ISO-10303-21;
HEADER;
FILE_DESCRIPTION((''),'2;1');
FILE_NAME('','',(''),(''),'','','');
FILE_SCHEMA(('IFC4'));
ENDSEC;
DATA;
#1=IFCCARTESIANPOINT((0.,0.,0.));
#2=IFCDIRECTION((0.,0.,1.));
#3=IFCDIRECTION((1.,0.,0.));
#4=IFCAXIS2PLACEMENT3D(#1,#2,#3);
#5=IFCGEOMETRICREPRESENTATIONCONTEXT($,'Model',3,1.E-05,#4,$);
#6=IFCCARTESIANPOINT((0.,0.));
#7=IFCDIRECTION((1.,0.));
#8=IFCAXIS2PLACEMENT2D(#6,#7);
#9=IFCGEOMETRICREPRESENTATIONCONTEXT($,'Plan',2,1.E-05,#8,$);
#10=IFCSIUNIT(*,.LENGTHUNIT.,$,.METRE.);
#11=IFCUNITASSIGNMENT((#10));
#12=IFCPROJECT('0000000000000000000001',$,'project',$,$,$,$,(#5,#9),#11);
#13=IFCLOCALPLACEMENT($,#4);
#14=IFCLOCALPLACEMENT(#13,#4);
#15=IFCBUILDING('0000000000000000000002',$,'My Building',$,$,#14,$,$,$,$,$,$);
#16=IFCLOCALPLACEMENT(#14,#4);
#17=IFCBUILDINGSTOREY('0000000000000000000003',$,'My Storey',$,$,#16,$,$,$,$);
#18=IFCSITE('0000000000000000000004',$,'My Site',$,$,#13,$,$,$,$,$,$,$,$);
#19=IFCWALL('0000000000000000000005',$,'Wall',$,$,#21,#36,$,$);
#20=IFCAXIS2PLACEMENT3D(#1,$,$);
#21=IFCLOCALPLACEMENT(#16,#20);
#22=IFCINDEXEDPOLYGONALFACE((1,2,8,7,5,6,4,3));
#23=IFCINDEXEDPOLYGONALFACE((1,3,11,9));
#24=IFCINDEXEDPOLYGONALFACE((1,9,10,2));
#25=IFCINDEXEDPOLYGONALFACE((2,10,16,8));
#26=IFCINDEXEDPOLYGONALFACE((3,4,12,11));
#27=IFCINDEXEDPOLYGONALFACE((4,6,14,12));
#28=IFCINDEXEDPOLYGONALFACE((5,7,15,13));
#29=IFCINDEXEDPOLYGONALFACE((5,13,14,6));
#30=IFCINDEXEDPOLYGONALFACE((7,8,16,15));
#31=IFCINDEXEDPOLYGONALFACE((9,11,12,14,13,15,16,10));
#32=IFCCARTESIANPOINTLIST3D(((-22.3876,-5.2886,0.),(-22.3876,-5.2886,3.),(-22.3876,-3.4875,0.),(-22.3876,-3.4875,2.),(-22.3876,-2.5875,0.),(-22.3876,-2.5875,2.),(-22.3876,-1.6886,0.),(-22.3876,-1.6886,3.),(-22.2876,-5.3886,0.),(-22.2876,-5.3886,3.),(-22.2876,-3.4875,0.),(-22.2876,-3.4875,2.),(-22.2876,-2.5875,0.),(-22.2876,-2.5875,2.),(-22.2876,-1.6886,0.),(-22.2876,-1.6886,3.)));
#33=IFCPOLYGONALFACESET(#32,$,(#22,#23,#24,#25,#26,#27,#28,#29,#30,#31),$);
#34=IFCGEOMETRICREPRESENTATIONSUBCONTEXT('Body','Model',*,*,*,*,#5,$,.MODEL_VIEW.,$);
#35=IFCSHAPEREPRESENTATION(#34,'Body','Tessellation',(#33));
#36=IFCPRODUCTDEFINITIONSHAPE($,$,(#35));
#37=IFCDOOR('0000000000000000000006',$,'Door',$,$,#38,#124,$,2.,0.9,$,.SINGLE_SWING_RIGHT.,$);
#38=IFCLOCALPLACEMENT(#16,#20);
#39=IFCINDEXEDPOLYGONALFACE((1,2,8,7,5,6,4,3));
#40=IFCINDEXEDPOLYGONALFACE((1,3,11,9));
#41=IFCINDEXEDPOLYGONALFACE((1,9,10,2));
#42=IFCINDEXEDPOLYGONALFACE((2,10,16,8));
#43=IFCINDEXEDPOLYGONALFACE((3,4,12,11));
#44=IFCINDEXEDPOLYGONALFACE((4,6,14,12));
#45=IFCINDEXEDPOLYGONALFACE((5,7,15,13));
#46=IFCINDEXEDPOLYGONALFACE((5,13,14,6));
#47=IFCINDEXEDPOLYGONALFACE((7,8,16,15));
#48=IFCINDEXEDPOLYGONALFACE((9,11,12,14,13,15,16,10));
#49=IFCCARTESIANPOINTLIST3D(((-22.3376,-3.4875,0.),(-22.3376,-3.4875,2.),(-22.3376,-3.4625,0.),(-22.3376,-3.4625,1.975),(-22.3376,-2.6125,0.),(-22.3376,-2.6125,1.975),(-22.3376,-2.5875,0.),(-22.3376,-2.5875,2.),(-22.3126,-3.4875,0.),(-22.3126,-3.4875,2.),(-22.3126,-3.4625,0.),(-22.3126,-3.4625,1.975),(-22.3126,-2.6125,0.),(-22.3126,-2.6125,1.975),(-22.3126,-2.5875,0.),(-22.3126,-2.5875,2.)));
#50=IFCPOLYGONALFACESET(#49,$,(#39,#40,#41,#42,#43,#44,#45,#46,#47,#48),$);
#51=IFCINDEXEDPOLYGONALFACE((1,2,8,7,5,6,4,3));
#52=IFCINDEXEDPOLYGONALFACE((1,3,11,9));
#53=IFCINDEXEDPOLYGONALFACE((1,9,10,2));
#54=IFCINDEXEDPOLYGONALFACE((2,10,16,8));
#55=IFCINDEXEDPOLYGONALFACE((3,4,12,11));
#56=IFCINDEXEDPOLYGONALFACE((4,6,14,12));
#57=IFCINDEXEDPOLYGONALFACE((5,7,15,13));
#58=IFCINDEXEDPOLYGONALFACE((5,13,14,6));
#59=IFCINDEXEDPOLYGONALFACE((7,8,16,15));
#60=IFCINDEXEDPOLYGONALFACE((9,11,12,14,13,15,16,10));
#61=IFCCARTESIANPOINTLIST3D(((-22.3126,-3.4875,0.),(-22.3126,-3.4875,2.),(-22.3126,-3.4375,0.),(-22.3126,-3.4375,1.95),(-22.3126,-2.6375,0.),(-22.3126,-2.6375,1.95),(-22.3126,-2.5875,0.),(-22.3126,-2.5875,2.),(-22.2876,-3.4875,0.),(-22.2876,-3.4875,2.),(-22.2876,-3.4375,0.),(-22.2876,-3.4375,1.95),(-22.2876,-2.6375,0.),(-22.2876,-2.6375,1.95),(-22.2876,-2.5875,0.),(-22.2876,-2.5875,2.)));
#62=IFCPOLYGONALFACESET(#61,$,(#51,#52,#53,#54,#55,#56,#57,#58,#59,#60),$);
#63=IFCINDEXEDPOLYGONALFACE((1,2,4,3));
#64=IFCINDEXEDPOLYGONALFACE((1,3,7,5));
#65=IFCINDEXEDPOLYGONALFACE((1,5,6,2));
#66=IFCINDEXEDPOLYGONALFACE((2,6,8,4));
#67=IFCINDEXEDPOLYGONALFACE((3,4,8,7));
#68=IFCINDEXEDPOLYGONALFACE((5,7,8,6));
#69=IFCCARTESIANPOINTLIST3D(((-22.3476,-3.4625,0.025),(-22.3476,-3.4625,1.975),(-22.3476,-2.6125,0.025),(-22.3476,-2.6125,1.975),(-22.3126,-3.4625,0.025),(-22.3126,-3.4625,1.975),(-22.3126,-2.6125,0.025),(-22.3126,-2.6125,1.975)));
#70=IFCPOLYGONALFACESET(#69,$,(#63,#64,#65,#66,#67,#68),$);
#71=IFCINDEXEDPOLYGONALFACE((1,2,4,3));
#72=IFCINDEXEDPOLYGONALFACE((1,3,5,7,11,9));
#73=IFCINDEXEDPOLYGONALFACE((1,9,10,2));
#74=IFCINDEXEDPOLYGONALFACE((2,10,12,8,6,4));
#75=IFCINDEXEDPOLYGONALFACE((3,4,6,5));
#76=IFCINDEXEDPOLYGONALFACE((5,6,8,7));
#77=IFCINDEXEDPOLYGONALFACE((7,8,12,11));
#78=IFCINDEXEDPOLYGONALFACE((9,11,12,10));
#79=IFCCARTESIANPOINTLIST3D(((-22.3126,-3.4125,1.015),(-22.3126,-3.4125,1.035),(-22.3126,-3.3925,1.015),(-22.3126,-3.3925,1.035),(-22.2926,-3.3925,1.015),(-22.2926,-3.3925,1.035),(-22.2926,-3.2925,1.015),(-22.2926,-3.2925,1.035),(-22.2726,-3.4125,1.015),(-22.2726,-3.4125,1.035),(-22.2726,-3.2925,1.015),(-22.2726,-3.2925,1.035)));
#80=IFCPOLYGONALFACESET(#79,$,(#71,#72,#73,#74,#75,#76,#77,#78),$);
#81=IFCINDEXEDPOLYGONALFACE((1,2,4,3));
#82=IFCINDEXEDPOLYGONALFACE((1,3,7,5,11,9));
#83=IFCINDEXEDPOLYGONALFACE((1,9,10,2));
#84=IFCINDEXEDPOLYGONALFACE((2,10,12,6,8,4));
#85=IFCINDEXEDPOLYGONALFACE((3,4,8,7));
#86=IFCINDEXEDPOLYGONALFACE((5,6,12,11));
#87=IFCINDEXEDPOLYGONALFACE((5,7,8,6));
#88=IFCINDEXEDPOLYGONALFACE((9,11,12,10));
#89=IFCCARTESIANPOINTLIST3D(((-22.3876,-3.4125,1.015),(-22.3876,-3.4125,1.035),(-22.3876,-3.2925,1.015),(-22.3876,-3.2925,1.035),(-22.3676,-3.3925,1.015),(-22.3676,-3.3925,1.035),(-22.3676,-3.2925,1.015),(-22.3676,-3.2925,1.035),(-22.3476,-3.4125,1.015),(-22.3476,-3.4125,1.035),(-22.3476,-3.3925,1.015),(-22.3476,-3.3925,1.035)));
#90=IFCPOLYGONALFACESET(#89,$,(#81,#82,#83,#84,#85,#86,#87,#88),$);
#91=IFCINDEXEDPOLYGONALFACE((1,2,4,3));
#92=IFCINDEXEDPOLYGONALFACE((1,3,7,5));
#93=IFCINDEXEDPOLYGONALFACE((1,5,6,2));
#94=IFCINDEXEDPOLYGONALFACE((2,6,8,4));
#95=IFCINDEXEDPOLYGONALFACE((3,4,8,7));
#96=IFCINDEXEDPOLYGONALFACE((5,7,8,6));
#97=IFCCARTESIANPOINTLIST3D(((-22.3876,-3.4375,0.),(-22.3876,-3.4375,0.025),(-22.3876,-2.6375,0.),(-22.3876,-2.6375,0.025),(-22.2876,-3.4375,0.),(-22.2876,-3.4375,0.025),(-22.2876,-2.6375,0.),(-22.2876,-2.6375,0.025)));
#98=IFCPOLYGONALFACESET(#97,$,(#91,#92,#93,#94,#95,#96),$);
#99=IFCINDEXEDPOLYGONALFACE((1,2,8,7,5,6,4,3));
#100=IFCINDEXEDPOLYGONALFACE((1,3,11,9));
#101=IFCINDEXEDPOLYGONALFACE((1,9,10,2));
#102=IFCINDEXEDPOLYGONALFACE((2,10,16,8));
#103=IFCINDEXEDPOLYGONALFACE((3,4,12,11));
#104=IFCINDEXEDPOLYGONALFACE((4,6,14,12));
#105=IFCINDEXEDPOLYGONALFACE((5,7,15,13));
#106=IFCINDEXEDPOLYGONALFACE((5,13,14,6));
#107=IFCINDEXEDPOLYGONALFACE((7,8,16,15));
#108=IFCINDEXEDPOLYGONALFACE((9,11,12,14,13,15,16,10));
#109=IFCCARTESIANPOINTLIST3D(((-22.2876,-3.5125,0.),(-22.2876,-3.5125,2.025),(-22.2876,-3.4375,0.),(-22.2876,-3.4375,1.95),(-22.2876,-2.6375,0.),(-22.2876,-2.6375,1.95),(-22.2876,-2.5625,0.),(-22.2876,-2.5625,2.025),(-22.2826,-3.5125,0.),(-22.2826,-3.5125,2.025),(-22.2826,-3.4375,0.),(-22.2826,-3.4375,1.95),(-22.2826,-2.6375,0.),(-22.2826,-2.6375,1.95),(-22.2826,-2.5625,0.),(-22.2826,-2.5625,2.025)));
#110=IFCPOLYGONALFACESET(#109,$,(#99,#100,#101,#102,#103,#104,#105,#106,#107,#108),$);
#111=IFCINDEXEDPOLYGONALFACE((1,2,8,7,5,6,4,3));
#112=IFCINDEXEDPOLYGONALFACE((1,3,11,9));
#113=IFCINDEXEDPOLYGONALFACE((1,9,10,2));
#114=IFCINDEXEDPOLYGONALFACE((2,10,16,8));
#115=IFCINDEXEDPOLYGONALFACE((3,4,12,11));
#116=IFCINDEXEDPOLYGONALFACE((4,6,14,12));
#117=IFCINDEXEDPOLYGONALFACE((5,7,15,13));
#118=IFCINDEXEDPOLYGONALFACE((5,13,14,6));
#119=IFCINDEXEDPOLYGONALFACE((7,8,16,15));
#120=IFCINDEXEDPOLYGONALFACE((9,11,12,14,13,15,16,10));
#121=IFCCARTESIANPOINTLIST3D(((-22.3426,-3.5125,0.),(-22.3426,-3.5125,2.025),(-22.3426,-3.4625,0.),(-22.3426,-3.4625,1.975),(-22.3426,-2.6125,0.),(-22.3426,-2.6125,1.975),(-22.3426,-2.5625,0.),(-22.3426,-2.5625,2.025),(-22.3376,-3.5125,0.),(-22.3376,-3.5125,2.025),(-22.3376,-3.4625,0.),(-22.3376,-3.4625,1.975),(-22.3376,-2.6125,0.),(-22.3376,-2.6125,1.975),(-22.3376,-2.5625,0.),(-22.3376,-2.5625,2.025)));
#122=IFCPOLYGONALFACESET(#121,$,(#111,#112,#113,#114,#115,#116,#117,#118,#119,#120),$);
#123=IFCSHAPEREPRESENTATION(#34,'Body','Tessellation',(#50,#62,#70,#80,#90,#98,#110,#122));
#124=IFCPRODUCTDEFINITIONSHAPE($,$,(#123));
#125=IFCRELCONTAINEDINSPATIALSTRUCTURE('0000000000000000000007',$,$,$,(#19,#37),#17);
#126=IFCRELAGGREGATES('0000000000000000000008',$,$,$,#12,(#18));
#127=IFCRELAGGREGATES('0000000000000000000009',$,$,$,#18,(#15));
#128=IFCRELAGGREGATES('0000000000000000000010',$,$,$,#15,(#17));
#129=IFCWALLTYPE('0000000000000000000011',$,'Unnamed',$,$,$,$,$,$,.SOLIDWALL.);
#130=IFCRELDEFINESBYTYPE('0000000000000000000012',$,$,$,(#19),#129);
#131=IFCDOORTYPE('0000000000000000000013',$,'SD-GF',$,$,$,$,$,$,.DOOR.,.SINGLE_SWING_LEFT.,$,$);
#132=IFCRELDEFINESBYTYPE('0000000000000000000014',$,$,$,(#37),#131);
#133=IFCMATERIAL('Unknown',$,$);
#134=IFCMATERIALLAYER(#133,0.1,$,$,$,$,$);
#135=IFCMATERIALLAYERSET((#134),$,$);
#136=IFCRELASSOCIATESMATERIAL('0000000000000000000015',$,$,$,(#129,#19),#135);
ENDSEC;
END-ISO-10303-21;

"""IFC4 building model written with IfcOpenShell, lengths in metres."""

from ifc_helpers import new_model, entity, si_unit, frame, origin_with_axes, origin_2d_with_axis, place, context, subcontext, project, spatial, line, indexed_curve, outline, extrude, shape, source, transform, mapped, material, layer, layer_set, layer_usage, type_object, type_shapes, element, fill, save


model = new_model("IFC4")

# Units and contexts
model_context = context("Model", 3, precision=1e-05, world=origin_with_axes())
plan_context = context("Plan", 2, precision=1e-05, world=origin_2d_with_axis())
body_context_1 = subcontext(model_context, "Body", "Model", "MODEL_VIEW")
body_context_2 = subcontext(plan_context, "Body", "Plan", "PLAN_VIEW")
ifc_project = project(units=[si_unit("LENGTHUNIT", "METRE")], contexts=[model_context, plan_context])

# Site, building, storey
site_placement = place(None, origin_with_axes())
site = spatial("IfcSite", under=ifc_project, at=site_placement, Name="My Site")
building_placement = place(site_placement, origin_with_axes())
building = spatial("IfcBuilding", under=site, at=building_placement, Name="My Building")
storey_placement = place(building_placement, origin_with_axes())
storey = spatial("IfcBuildingStorey", under=building, at=storey_placement, Name="My Storey")

# Shared definitions
ifc_material = material(Name="Unknown")

# Shared definitions
ifc_layer = layer(ifc_material, 0.1)
ifc_layer_set = layer_set([ifc_layer])
wall_type = type_object("IfcWallType", Name="Unnamed", PredefinedType="SOLIDWALL", material=ifc_layer_set)

# Wall, opening, door
ifc_layer_usage_1 = layer_usage(ifc_layer_set, "AXIS2", "POSITIVE", 0.0)
wall_1_placement = place(storey_placement, frame((-22.3876, -1.6886, 0.0), z_axis=(0.0, 0.0, 1.0), x_axis=(0.0, -1.0, 0.0)))
wall_1 = element("IfcWall", 1, at=wall_1_placement, inside=storey, type_object=wall_type, material=ifc_layer_usage_1, Name="Wall", context=body_context_1, shape_type="SweptSolid", body=[
    extrude(outline(indexed_curve([(0.0, 0.0), (0.0, 0.1), (3.7, 0.1), (3.6, 0.0)], segments=[line(1, 2, 3, 4, 1)])), origin_with_axes(), (0.0, 0.0, 1.0), 3.0),
])
shared_shape_1 = source(origin_with_axes(), body_context_1, "Body", "SweptSolid", [
    extrude(outline(indexed_curve([(0.0, 0.0), (0.9, 0.0), (0.9, 2.0), (0.0, 2.0)], segments=[line(1, 2, 3, 4, 1)])), frame((0.0, -0.6, 0.0), z_axis=(0.0, -1.0, 0.0), x_axis=(1.0, 0.0, 0.0)), (0.0, 0.0, -1.0), 1.2),
])
opening_1_placement = place(wall_1_placement, frame((1.7988, 0.1, 0.0), z_axis=(0.0, 0.0, 1.0), x_axis=(-1.0, 0.0, 0.0)))
opening_1 = element("IfcOpeningElement", 2, at=opening_1_placement, cuts=wall_1, PredefinedType="OPENING", context=body_context_1, shape_type="MappedRepresentation", body=[
    mapped(shared_shape_1, transform((0.0, 0.0, 0.0), x_axis=(1.0, 0.0, 0.0), y_axis=(0.0, 1.0, 0.0), z_axis=(0.0, 0.0, 1.0), scale=1.0)),
])
door_type = type_object("IfcDoorType", Name="SD-GF", OperationType="SINGLE_SWING_LEFT", PredefinedType="DOOR")
shared_shape_2 = source(origin_with_axes(), body_context_1, "Body", "SweptSolid", [
    extrude(outline(indexed_curve([(0.0, 0.0), (0.0, 2.0), (0.9, 2.0), (0.9, 0.0), (0.875, 0.0), (0.875, 1.975), (0.025, 1.975), (0.025, 0.0)], segments=[line(1, 2, 3, 4, 5, 6, 7, 8, 1)])), frame((0.0, 0.025, 0.0), z_axis=(0.0, -1.0, 0.0), x_axis=(1.0, 0.0, 0.0)), (0.0, 0.0, -1.0), 0.025),
    extrude(outline(indexed_curve([(0.0, 0.0), (0.0, 2.0), (0.9, 2.0), (0.9, 0.0), (0.85, 0.0), (0.85, 1.95), (0.05, 1.95), (0.05, 0.0)], segments=[line(1, 2, 3, 4, 5, 6, 7, 8, 1)])), frame((0.0, 0.0, 0.0), z_axis=(0.0, -1.0, 0.0), x_axis=(1.0, 0.0, 0.0)), (0.0, 0.0, -1.0), 0.025),
    extrude(outline(indexed_curve([(0.0, 0.0), (0.85, 0.0), (0.85, 0.035), (0.0, 0.035)], segments=[line(1, 2, 3, 4, 1)])), frame((0.025, 0.025, 0.025), z_axis=(0.0, 0.0, 1.0), x_axis=(1.0, 0.0, 0.0)), (0.0, 0.0, 1.0), 1.95),
    extrude(outline(indexed_curve([(0.0, 0.0), (0.0, -0.04), (0.12, -0.04), (0.12, -0.02), (0.02, -0.02), (0.02, 0.0)], segments=[line(1, 2, 3, 4, 5, 6, 1)])), frame((0.075, 0.025, 1.015), z_axis=(0.0, 0.0, 1.0), x_axis=(1.0, 0.0, 0.0)), (0.0, 0.0, 1.0), 0.02),
    extrude(outline(indexed_curve([(0.0, 0.0), (0.0, 0.04), (0.12, 0.04), (0.12, 0.02), (0.02, 0.02), (0.02, 0.0)], segments=[line(1, 2, 3, 4, 5, 6, 1)])), frame((0.075, 0.06, 1.015), z_axis=(0.0, 0.0, 1.0), x_axis=(1.0, 0.0, 0.0)), (0.0, 0.0, 1.0), 0.02),
    extrude(outline(indexed_curve([(0.0, 0.0), (0.8, 0.0), (0.8, 0.1), (0.0, 0.1)], segments=[line(1, 2, 3, 4, 1)])), frame((0.05, 0.0, 0.0), z_axis=(0.0, 0.0, 1.0), x_axis=(1.0, 0.0, 0.0)), (0.0, 0.0, 1.0), 0.025),
    extrude(outline(indexed_curve([(0.0, 0.0), (0.0, 2.025), (0.95, 2.025), (0.95, 0.0), (0.875, 0.0), (0.875, 1.95), (0.075, 1.95), (0.075, 0.0)], segments=[line(1, 2, 3, 4, 5, 6, 7, 8, 1)])), frame((-0.025, -0.005, 0.0), z_axis=(0.0, -1.0, 0.0), x_axis=(1.0, 0.0, 0.0)), (0.0, 0.0, -1.0), 0.005),
    extrude(outline(indexed_curve([(0.0, 0.0), (0.0, 2.025), (0.95, 2.025), (0.95, 0.0), (0.9, 0.0), (0.9, 1.975), (0.05, 1.975), (0.05, 0.0)], segments=[line(1, 2, 3, 4, 5, 6, 7, 8, 1)])), frame((-0.025, 0.05, 0.0), z_axis=(0.0, -1.0, 0.0), x_axis=(1.0, 0.0, 0.0)), (0.0, 0.0, -1.0), 0.005),
])
shared_shape_3 = source(origin_with_axes(), body_context_2, "Body", "Curve2D", [
    entity("IfcIndexedPolyCurve", entity("IfcCartesianPointList2D", [[0.0, 0.0], [0.0, 0.05], [0.025, 0.05], [0.025, 0.025], [0.05, 0.025], [0.05, 0.0]]), [entity("IfcLineIndex", [1, 2, 3, 4, 5, 6, 1])]),
    entity("IfcIndexedPolyCurve", entity("IfcCartesianPointList2D", [[0.9, 0.0], [0.9, 0.05], [0.875, 0.05], [0.875, 0.025], [0.85, 0.025], [0.85, 0.0]]), [entity("IfcLineIndex", [1, 2, 3, 4, 5, 6, 1])]),
    entity("IfcTrimmedCurve", entity("IfcEllipse", entity("IfcAxis2Placement2D", entity("IfcCartesianPoint", [0.84, 0.05]), entity("IfcDirection", [1.0, 0.0])), 0.815, 0.85), [entity("IfcCartesianPoint", [0.84, 0.9])], [entity("IfcCartesianPoint", [0.025, 0.05])], True, "CARTESIAN"),
    entity("IfcIndexedPolyCurve", entity("IfcCartesianPointList2D", [[0.875, 0.05], [0.84, 0.05], [0.84, 0.9], [0.875, 0.9]]), [entity("IfcLineIndex", [1, 2, 3, 4, 1])]),
])
type_shapes(door_type, [shared_shape_2, shared_shape_3])
door_1_placement = place(opening_1_placement, frame((0.0, 0.0, 0.0), z_axis=(0.0, 0.0, 1.0), x_axis=(1.0, 0.0, 0.0)))
door_1 = element("IfcDoor", 3, at=door_1_placement, inside=storey, type_object=door_type, Name="Door", OperationType="SINGLE_SWING_RIGHT", OverallHeight=2.0, OverallWidth=0.9, shapes=[
    shape(body_context_1, "Body", "MappedRepresentation", [mapped(shared_shape_2, transform((0.0, 0.0, 0.0), x_axis=(1.0, 0.0, 0.0), y_axis=(0.0, 1.0, 0.0), z_axis=(0.0, 0.0, 1.0), scale=1.0))]),
    shape(body_context_2, "Body", "MappedRepresentation", [mapped(shared_shape_3, transform((0.0, 0.0, 0.0), x_axis=(1.0, 0.0, 0.0), y_axis=(0.0, 1.0, 0.0), z_axis=(0.0, 0.0, 1.0), scale=1.0))]),
])
fill(opening_1, door_1)

save(model, "model.ifc")
